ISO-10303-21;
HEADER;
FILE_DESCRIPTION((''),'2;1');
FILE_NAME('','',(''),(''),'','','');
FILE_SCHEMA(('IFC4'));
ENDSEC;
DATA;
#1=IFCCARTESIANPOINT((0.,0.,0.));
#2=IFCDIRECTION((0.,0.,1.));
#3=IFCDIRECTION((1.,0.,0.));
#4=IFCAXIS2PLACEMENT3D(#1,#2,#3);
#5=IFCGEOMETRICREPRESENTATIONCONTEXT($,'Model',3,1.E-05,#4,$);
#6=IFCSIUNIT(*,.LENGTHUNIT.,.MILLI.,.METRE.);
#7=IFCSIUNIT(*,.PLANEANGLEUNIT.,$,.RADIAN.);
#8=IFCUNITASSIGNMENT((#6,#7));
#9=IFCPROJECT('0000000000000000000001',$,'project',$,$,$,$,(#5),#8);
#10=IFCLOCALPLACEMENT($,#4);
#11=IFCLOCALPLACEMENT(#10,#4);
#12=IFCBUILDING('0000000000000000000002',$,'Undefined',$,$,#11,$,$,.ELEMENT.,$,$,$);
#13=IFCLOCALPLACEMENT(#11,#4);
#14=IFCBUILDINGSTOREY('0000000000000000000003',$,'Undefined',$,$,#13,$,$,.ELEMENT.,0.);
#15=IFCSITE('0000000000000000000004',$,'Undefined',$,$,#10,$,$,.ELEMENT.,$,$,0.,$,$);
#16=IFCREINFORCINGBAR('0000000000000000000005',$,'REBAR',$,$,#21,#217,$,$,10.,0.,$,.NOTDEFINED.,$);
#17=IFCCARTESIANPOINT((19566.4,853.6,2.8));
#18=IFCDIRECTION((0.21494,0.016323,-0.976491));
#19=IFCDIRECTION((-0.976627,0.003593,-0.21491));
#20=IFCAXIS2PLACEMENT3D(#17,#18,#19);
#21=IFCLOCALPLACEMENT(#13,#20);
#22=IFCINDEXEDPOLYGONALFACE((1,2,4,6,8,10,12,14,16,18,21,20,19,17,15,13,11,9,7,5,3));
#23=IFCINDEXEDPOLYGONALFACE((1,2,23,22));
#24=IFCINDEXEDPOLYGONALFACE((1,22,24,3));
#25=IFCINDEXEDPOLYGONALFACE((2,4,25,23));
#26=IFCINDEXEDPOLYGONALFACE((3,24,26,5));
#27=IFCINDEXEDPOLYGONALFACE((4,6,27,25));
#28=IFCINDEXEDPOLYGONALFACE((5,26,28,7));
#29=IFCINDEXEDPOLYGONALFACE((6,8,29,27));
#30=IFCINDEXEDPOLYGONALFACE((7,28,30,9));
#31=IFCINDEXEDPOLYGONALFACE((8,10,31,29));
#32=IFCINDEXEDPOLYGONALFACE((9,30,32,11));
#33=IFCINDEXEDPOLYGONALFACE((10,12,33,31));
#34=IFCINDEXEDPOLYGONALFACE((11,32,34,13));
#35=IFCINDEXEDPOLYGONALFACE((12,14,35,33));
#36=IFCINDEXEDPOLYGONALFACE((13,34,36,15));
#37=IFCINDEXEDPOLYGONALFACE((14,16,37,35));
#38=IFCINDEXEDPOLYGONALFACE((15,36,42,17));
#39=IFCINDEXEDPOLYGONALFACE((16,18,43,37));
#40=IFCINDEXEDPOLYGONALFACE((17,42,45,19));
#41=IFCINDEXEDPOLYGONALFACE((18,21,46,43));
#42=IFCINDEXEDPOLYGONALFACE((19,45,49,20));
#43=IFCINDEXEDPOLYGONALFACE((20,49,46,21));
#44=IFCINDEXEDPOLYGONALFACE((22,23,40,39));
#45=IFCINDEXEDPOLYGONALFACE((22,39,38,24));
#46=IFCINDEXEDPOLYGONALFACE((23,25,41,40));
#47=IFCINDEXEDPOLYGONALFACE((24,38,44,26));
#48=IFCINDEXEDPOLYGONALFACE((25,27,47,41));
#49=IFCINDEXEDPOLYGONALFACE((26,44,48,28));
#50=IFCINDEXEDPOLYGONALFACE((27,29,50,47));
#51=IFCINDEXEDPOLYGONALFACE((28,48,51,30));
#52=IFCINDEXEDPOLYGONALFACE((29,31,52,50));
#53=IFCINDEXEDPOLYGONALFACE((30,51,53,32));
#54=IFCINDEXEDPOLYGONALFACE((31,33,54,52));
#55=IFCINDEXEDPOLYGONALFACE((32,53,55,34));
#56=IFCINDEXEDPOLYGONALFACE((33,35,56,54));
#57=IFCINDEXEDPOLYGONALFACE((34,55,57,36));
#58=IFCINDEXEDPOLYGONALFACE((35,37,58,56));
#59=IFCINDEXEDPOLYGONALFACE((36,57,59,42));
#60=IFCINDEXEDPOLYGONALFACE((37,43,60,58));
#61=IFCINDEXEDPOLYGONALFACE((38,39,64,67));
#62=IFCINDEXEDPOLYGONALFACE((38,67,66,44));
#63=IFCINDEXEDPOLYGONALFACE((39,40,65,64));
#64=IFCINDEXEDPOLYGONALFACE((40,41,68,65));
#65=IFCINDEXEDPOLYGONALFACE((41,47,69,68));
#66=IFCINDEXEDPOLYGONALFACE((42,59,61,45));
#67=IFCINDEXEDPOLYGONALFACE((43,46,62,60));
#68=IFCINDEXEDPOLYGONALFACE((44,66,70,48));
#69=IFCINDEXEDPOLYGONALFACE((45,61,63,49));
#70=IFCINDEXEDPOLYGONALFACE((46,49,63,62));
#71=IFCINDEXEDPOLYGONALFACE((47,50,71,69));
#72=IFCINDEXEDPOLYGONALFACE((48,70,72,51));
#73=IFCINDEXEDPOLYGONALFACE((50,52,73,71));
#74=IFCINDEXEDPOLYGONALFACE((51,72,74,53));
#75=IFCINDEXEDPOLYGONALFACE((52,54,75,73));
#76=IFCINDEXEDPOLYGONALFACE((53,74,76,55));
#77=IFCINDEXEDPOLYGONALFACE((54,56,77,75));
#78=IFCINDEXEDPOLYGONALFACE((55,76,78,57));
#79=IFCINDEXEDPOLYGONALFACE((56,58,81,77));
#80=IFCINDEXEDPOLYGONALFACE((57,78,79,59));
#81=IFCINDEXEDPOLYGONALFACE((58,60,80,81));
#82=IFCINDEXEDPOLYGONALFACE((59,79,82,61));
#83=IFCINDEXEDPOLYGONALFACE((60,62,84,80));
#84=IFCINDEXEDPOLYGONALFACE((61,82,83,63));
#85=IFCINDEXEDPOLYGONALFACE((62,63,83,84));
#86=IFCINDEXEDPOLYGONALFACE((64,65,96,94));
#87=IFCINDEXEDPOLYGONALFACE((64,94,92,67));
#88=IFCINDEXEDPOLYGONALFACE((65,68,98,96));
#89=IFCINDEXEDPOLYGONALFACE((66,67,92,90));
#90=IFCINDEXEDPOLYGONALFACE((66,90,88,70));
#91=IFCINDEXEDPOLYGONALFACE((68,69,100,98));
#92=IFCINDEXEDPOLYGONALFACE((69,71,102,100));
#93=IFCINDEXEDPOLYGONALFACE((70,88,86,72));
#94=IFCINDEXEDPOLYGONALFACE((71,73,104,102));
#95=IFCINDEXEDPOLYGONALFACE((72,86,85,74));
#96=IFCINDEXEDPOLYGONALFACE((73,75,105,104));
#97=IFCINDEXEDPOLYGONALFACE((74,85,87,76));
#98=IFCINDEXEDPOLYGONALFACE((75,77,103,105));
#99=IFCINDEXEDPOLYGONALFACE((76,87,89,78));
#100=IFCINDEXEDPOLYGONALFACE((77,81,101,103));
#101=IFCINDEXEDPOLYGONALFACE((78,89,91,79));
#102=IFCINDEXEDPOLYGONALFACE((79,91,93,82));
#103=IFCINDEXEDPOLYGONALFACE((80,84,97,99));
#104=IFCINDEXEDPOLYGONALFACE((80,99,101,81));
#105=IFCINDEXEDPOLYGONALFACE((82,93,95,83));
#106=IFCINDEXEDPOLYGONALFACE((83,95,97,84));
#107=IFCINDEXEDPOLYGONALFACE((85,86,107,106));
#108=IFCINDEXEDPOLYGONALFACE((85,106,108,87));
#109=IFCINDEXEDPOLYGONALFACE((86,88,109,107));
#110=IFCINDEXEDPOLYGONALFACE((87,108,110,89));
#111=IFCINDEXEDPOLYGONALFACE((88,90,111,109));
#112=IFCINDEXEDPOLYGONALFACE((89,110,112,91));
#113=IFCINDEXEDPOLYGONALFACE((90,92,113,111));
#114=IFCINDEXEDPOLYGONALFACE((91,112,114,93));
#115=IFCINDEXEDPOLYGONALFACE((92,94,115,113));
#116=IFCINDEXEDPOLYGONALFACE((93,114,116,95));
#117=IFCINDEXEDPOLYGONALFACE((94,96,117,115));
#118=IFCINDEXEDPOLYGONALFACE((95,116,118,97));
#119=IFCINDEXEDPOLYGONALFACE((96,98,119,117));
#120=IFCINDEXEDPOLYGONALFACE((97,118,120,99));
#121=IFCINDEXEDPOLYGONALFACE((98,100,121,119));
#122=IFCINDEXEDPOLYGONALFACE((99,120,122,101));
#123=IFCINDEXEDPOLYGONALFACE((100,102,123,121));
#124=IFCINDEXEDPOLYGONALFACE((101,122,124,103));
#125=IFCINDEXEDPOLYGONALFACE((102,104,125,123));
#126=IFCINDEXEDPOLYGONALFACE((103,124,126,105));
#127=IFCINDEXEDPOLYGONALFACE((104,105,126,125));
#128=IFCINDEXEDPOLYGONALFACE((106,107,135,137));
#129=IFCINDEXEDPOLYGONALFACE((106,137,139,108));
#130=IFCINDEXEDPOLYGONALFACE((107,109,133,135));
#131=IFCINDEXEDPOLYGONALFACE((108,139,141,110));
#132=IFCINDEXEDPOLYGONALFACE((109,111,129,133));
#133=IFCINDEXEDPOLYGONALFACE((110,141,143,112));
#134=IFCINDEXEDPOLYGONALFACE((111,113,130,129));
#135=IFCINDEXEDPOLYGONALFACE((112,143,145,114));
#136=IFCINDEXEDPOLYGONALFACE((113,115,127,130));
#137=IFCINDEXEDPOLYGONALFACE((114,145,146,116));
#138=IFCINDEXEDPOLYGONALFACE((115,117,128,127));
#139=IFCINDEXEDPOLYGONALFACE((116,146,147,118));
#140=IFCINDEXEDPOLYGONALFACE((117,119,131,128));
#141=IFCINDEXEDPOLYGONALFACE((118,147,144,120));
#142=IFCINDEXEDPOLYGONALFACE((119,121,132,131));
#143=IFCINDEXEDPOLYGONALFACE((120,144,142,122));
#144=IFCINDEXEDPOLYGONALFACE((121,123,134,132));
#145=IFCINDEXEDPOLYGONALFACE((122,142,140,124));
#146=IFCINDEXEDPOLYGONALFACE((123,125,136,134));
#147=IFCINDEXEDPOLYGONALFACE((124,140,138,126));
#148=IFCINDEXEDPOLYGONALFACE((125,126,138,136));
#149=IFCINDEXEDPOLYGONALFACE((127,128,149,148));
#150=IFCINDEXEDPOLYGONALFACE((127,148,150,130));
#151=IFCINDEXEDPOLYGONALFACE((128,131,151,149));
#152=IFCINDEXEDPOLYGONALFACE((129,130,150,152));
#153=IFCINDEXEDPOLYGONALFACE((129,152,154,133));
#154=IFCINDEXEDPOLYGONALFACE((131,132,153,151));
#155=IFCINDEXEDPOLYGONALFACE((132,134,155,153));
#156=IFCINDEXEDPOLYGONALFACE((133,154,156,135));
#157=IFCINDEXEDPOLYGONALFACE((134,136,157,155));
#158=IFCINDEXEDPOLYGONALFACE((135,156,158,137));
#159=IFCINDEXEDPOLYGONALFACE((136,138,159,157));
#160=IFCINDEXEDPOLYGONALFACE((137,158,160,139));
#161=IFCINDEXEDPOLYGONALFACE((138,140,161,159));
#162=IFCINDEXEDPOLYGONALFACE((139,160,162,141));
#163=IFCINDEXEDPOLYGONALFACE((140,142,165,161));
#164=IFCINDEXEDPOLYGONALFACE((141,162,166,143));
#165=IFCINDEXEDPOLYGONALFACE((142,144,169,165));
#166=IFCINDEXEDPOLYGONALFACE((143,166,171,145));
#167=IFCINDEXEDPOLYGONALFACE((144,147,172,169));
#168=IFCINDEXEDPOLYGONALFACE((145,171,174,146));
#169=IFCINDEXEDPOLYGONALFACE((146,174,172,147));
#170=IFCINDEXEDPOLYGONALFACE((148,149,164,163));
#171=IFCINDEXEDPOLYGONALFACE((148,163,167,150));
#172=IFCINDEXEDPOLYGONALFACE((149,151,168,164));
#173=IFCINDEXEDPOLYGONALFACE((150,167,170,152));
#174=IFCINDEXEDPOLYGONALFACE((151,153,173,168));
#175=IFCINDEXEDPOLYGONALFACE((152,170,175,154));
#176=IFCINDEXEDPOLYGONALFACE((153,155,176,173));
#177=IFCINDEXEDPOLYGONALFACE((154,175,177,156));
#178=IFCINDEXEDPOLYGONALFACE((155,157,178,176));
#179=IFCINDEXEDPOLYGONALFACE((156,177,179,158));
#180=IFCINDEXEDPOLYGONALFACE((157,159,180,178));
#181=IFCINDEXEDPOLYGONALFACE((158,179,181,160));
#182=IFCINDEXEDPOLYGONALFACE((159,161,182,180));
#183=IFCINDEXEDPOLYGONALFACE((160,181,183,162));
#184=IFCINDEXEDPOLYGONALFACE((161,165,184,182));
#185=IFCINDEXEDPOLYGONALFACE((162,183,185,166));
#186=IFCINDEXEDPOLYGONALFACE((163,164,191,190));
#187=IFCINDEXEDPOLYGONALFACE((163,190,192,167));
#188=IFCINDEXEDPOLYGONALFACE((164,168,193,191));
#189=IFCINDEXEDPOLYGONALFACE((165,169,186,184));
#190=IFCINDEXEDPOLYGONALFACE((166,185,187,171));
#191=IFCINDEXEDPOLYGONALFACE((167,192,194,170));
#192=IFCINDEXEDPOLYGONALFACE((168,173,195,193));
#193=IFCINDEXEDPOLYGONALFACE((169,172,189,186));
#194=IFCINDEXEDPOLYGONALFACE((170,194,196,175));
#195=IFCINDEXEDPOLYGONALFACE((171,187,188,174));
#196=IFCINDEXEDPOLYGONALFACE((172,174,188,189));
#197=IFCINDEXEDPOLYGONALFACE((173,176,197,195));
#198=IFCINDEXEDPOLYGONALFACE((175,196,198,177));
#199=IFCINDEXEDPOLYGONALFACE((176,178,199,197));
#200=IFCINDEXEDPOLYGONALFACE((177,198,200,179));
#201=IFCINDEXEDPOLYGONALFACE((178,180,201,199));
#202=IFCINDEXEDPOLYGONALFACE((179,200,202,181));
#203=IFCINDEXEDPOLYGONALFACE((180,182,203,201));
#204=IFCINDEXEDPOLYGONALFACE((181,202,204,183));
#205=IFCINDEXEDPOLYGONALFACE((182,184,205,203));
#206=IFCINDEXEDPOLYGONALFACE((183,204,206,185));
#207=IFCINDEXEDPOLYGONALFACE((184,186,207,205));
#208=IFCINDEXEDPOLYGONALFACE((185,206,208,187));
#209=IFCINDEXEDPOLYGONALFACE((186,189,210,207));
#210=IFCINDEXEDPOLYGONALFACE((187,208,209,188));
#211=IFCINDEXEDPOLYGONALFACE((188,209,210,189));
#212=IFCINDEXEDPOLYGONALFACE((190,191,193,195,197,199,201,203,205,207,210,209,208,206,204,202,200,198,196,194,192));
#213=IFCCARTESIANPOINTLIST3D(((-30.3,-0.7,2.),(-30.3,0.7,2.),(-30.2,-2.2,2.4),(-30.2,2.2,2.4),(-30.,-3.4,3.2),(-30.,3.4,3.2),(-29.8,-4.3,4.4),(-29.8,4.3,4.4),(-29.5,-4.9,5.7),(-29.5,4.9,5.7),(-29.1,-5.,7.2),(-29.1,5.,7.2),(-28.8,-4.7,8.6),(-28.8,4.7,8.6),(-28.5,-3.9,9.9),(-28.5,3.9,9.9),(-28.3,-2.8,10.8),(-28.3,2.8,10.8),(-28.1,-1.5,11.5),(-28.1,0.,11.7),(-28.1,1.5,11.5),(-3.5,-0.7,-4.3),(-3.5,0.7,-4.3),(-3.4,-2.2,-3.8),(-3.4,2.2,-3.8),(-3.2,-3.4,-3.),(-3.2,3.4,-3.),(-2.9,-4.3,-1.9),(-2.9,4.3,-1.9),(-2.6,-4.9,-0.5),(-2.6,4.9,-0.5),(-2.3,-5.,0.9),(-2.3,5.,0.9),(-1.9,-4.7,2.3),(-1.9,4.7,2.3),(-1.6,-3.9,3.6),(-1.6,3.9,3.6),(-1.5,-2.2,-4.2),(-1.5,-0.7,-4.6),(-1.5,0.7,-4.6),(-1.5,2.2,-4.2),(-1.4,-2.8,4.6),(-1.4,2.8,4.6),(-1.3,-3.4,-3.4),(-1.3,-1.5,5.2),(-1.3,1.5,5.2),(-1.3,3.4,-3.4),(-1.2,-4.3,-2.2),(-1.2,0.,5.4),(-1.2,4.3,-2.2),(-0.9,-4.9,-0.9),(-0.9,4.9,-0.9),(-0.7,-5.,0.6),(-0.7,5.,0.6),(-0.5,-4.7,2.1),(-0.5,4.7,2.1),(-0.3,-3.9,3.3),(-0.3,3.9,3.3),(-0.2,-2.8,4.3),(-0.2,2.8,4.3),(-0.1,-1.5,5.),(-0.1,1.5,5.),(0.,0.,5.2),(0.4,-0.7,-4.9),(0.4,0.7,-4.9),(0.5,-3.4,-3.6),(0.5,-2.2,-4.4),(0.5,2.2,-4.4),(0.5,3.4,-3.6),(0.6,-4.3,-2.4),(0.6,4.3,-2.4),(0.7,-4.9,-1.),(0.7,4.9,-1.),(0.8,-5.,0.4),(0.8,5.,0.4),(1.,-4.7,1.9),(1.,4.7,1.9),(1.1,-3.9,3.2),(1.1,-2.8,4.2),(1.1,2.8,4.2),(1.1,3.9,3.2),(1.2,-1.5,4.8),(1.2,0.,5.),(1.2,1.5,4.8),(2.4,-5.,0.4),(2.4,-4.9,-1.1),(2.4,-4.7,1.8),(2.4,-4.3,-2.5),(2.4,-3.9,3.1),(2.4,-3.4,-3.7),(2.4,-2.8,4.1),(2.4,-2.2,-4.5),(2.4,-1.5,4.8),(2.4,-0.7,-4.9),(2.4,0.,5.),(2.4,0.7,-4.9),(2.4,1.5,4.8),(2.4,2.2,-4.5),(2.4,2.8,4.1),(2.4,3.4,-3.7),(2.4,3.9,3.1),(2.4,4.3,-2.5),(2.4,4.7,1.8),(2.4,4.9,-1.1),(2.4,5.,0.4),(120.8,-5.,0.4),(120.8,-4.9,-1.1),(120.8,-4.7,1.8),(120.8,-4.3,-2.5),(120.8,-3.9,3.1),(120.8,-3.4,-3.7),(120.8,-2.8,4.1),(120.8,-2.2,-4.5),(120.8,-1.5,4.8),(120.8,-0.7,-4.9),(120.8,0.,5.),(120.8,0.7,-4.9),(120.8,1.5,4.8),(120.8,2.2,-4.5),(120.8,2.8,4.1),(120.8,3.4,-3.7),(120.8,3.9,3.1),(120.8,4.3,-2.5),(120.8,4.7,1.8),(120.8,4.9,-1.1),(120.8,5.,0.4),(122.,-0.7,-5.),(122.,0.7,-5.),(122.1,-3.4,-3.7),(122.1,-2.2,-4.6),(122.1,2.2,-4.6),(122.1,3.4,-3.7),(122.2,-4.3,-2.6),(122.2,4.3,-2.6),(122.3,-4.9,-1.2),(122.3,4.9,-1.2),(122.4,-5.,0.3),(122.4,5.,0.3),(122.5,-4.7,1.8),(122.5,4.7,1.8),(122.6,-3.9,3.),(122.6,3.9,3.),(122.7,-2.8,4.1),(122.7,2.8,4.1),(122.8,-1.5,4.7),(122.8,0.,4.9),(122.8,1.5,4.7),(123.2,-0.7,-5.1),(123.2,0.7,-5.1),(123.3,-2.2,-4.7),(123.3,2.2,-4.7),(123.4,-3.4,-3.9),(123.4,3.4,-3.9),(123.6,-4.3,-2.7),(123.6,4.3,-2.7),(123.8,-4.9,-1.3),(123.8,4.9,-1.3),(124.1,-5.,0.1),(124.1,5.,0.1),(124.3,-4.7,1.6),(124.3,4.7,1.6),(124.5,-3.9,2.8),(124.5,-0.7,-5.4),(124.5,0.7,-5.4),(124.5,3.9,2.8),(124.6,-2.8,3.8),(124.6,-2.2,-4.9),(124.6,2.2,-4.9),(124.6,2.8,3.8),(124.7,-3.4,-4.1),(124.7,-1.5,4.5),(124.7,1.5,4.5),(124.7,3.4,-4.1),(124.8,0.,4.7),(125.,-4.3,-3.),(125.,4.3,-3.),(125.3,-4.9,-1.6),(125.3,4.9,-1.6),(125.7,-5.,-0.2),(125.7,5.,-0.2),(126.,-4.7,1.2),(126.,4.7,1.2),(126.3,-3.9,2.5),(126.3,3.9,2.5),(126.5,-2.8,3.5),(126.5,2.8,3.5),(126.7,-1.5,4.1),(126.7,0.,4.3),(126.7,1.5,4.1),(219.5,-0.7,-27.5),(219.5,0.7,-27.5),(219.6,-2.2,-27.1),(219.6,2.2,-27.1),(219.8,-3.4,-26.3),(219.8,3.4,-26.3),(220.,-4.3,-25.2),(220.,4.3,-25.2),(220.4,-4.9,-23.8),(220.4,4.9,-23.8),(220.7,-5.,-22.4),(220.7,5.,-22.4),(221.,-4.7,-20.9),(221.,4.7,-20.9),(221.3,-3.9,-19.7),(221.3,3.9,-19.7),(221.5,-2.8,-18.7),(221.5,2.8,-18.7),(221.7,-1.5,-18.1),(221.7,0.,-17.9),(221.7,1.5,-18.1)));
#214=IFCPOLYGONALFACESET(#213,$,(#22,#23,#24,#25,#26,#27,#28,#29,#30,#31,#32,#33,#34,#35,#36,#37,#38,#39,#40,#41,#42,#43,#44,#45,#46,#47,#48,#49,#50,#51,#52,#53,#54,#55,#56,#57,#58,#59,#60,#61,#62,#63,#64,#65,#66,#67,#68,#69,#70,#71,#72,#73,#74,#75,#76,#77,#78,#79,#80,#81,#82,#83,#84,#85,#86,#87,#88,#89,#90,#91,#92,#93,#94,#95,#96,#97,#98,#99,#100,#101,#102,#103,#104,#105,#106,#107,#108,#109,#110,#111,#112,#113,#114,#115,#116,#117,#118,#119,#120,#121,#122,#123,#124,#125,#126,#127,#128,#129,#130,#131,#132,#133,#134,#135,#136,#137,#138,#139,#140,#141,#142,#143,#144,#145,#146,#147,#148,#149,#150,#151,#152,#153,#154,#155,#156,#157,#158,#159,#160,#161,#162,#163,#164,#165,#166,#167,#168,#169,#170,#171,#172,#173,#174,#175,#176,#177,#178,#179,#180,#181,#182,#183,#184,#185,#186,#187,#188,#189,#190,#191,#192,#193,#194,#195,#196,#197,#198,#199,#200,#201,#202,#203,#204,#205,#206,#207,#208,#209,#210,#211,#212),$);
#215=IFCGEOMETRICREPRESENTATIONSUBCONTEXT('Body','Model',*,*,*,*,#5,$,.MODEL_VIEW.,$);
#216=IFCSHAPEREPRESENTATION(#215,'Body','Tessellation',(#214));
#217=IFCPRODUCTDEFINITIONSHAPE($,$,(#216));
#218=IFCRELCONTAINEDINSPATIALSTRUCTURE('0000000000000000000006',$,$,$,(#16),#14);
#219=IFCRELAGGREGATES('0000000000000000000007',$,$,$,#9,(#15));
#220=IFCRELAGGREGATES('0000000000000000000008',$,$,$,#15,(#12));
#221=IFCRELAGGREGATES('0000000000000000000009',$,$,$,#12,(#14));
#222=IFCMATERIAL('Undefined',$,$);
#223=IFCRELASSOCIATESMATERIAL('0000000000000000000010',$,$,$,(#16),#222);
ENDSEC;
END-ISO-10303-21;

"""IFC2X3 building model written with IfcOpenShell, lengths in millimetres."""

from ifc_helpers import new_model, entity, si_unit, frame, origin_with_axes, place, context, subcontext, project, spatial, source, transform, mapped, material, element, save


model = new_model("IFC2X3")

# Units and contexts
model_context = context("Model", 3, precision=1e-05, world=origin_with_axes())
body_context = subcontext(model_context, "Body", "Model", "MODEL_VIEW")
ifc_project = project(units=[si_unit("LENGTHUNIT", "METRE", prefix="MILLI"), si_unit("PLANEANGLEUNIT", "RADIAN")], contexts=[model_context])

# Site, building, storey
site_placement = place(None, origin_with_axes())
site = spatial("IfcSite", under=ifc_project, at=site_placement, Name="Undefined", CompositionType="ELEMENT", RefElevation=0.0)
building_placement = place(site_placement, origin_with_axes())
building = spatial("IfcBuilding", under=site, at=building_placement, Name="Undefined", CompositionType="ELEMENT")
storey_placement = place(building_placement, origin_with_axes())
storey = spatial("IfcBuildingStorey", under=building, at=storey_placement, Name="Undefined", CompositionType="ELEMENT", Elevation=0.0)

# Reinforcing bar
ifc_material_1 = material(Name="Undefined")
ifc_direction_1 = entity("IfcDirection", [0.973841, 0.0, -0.22723])
shared_shape_1 = source(origin_with_axes(), body_context, "Body", "AdvancedSweptSolid", [
    entity("IfcSweptDiskSolid", entity("IfcCompositeCurve", [entity("IfcCompositeCurveSegment", "CONTINUOUS", True, entity("IfcTrimmedCurve", entity("IfcLine", entity("IfcCartesianPoint", [0.0, 0.0, 0.0]), entity("IfcVector", ifc_direction_1, 1.0)), [entity("IfcParameterValue", 0.0)], [entity("IfcParameterValue", 27.582469)], True, "PARAMETER")), entity("IfcCompositeCurveSegment", "CONTINUOUS", True, entity("IfcTrimmedCurve", entity("IfcCircle", entity("IfcAxis2Placement3D", entity("IfcCartesianPoint", [31.6, 0.0, 14.2]), entity("IfcDirection", [0.0, -1.0, 0.0]), entity("IfcDirection", [-0.22723, 0.0, -0.973841])), 21.0), [entity("IfcParameterValue", 0.0)], [entity("IfcParameterValue", 0.229232)], True, "PARAMETER")), entity("IfcCompositeCurveSegment", "CONTINUOUS", True, entity("IfcTrimmedCurve", entity("IfcLine", entity("IfcCartesianPoint", [31.6, 0.0, -6.8]), entity("IfcVector", entity("IfcDirection", [1.0, 0.0, 0.0]), 1.0)), [entity("IfcParameterValue", 0.0)], [entity("IfcParameterValue", 118.388313)], True, "PARAMETER")), entity("IfcCompositeCurveSegment", "CONTINUOUS", True, entity("IfcTrimmedCurve", entity("IfcCircle", entity("IfcAxis2Placement3D", entity("IfcCartesianPoint", [150.0, 0.0, -27.8]), entity("IfcDirection", [0.0, 1.0, 0.0]), entity("IfcDirection", [0.0, 0.0, 1.0])), 21.0), [entity("IfcParameterValue", 0.0)], [entity("IfcParameterValue", 0.229232)], True, "PARAMETER")), entity("IfcCompositeCurveSegment", "DISCONTINUOUS", True, entity("IfcTrimmedCurve", entity("IfcLine", entity("IfcCartesianPoint", [154.8, 0.0, -7.4]), entity("IfcVector", ifc_direction_1, 1.0)), [entity("IfcParameterValue", 0.0)], [entity("IfcParameterValue", 97.582469)], True, "PARAMETER"))], False), 5.0, None, 0.0, 244.0),
])
reinforcing_bar_1_placement = place(storey_placement, frame((19566.4, 853.6, 2.8), z_axis=(0.21494, 0.016323, -0.976491), x_axis=(-0.976627, 0.003593, -0.21491)))
element("IfcReinforcingBar", 1, at=reinforcing_bar_1_placement, inside=storey, material=ifc_material_1, Name="REBAR", BarRole="NOTDEFINED", CrossSectionArea=0.0, NominalDiameter=10.0, context=body_context, shape_type="MappedRepresentation", body=[
    mapped(shared_shape_1, transform((-29.2, 0.0, 6.8))),
])

save(model, "model.ifc")
